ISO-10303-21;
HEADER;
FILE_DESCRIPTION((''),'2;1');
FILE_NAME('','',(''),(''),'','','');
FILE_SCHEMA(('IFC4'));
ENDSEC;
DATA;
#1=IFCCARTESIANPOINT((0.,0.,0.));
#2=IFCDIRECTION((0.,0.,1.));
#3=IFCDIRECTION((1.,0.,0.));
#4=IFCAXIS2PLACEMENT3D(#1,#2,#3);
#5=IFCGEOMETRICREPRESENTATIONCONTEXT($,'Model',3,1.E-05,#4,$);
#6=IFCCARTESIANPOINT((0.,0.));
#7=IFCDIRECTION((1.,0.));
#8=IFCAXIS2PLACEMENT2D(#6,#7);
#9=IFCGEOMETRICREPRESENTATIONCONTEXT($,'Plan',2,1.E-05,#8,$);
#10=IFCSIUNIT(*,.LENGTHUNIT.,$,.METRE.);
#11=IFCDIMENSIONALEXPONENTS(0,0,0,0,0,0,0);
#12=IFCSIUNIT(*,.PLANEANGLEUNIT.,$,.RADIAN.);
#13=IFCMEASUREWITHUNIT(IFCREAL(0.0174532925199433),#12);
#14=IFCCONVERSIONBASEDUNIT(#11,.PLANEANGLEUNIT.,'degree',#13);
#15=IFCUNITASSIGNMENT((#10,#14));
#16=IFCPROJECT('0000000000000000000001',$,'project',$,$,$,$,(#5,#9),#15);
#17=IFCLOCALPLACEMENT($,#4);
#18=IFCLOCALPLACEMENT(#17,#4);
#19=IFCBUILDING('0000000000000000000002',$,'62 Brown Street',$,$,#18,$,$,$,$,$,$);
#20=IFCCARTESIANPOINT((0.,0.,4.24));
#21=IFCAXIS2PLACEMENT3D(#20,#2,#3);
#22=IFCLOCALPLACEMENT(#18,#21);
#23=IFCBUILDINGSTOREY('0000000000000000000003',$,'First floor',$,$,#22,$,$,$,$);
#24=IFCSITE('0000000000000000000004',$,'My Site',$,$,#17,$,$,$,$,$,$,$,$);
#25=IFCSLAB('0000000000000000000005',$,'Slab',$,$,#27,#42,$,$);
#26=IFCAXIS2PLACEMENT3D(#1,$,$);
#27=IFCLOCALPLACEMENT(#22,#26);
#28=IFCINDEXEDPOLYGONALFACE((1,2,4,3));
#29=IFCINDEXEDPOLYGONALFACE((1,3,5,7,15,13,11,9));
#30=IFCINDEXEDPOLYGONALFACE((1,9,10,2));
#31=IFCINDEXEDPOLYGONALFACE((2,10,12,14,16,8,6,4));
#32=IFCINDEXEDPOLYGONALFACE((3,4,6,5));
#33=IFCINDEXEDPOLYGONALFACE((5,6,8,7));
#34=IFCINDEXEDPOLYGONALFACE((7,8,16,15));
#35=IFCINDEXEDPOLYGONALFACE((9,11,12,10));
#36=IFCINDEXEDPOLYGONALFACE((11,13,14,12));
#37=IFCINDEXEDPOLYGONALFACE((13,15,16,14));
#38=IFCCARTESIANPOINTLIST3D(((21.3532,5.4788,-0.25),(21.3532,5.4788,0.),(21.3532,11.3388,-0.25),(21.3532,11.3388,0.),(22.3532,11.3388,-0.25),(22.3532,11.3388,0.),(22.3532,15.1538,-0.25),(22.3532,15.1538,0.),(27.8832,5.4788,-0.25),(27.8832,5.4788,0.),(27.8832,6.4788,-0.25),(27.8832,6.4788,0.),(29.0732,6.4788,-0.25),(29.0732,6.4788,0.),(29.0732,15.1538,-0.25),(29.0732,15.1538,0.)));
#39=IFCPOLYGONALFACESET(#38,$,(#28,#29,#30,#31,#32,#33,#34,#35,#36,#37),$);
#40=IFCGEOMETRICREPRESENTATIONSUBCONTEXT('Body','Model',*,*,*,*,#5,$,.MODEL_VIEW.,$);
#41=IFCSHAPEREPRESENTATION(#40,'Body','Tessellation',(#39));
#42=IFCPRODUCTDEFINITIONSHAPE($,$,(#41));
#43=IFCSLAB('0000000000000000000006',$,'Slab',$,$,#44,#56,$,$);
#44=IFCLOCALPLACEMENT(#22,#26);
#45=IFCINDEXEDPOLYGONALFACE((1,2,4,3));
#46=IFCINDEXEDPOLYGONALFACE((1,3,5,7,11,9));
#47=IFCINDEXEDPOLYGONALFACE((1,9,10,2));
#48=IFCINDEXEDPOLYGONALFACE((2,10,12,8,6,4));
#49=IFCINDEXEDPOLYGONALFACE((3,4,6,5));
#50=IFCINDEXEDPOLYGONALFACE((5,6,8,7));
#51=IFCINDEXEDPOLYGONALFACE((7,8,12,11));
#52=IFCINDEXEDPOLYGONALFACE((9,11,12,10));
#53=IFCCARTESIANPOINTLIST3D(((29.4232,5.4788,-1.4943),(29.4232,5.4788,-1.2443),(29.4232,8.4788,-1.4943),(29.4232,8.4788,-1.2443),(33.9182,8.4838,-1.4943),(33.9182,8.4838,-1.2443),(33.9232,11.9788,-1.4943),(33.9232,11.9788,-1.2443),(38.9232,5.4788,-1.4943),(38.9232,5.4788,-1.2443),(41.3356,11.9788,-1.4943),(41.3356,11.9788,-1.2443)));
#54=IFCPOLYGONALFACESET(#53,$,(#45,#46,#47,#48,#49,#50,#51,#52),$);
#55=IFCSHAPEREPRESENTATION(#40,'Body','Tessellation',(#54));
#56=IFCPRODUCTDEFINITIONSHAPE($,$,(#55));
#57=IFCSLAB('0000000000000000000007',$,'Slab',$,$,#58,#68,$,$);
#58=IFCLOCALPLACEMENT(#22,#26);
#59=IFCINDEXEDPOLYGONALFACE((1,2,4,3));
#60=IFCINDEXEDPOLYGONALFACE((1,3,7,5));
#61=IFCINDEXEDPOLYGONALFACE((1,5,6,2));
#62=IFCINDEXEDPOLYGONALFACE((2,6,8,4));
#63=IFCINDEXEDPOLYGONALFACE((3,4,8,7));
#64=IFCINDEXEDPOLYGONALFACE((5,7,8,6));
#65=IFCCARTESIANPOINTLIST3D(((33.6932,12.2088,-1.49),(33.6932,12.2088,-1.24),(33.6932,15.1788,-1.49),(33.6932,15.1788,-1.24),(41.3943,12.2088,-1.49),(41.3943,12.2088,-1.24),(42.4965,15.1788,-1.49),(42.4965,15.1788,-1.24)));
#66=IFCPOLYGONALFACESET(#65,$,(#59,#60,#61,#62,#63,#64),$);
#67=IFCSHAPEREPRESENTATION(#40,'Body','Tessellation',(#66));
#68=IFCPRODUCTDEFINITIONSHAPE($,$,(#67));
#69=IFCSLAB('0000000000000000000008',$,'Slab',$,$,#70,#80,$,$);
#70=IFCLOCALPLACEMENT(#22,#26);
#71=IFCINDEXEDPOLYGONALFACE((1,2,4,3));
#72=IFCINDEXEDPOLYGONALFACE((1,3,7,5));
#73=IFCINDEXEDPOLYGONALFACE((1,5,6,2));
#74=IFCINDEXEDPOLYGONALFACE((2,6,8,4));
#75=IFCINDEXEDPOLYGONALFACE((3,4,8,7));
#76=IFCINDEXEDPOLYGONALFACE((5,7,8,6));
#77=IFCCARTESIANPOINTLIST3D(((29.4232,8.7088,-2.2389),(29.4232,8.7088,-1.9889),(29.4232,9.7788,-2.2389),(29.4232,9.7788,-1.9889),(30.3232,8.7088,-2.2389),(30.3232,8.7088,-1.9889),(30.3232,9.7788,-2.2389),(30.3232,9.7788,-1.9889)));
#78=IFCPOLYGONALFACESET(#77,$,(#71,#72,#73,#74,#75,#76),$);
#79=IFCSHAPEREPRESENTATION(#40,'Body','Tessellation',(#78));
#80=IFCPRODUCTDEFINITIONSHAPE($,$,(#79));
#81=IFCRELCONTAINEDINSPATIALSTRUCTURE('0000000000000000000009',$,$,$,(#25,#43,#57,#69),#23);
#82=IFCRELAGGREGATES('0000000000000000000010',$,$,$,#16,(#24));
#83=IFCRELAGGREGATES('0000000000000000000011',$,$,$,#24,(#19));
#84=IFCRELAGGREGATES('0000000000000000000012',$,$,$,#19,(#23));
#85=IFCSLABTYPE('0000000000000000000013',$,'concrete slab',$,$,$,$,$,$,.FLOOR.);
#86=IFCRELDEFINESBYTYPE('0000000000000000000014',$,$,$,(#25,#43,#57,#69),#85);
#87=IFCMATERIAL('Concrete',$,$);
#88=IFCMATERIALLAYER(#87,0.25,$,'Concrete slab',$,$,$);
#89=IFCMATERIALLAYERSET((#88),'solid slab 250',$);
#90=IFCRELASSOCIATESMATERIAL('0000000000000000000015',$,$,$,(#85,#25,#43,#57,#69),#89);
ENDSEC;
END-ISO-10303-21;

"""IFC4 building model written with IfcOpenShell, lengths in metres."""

from ifc_helpers import new_model, entity, si_unit, converted_unit, frame, origin_with_axes, origin_2d_with_axis, place, context, subcontext, project, spatial, line, indexed_curve, outline, extrude, material, layer, layer_set, layer_usage, type_object, element, save


model = new_model("IFC4")

# Units and contexts
model_context = context("Model", 3, precision=1e-05, world=origin_with_axes())
plan_context = context("Plan", 2, precision=1e-05, world=origin_2d_with_axis())
body_context = subcontext(model_context, "Body", "Model", "MODEL_VIEW")
ifc_project = project(units=[si_unit("LENGTHUNIT", "METRE"), converted_unit("PLANEANGLEUNIT", "degree", entity("IfcReal", 0.0174532925199433), si_unit("PLANEANGLEUNIT", "RADIAN"), dimensions=[0, 0, 0, 0, 0, 0, 0])], contexts=[model_context, plan_context])

# Site, building, storey
site_placement = place(None, origin_with_axes())
site = spatial("IfcSite", under=ifc_project, at=site_placement, Name="My Site")
building_placement = place(site_placement, origin_with_axes())
building = spatial("IfcBuilding", under=site, at=building_placement, Name="62 Brown Street")
storey_placement = place(building_placement, frame((0.0, 0.0, 4.24), z_axis=(0.0, 0.0, 1.0), x_axis=(1.0, 0.0, 0.0)))
storey = spatial("IfcBuildingStorey", under=building, at=storey_placement, Name="First floor")

# Slabs
ifc_material = material(Name="Concrete")
ifc_layer = layer(ifc_material, 0.25, Name="Concrete slab")
ifc_layer_set = layer_set([ifc_layer], Name="solid slab 250")
ifc_layer_usage_1 = layer_usage(ifc_layer_set, "AXIS3", "POSITIVE", 0.0)
slab_type = type_object("IfcSlabType", Name="concrete slab", PredefinedType="FLOOR", material=ifc_layer_set)
slab_1_placement = place(storey_placement, frame((21.3532, 5.4788, -0.25), z_axis=(0.0, 0.0, 1.0), x_axis=(1.0, 0.0, 0.0)))
element("IfcSlab", 1, at=slab_1_placement, inside=storey, type_object=slab_type, material=ifc_layer_usage_1, Name="Slab", context=body_context, shape_type="SweptSolid", body=[
    extrude(outline(indexed_curve([(0.0, 0.0), (0.0, 5.86), (1.0, 5.86), (1.0, 9.675), (7.72, 9.675), (7.72, 1.0), (6.53, 1.0), (6.53, 0.0)], segments=[line(2, 1), line(1, 8), line(8, 7), line(7, 6), line(6, 5), line(5, 4), line(4, 3), line(3, 2)], self_intersect=False)), None, (0.0, 0.0, 1.0), 0.25),
])
ifc_layer_usage_2 = layer_usage(ifc_layer_set, "AXIS3", "POSITIVE", 0.0)
slab_2_placement = place(storey_placement, frame((29.4232, 5.4788, -1.4943), z_axis=(0.0, 0.0, 1.0), x_axis=(1.0, 0.0, 0.0)))
element("IfcSlab", 2, at=slab_2_placement, inside=storey, type_object=slab_type, material=ifc_layer_usage_2, Name="Slab", context=body_context, shape_type="SweptSolid", body=[
    extrude(outline(indexed_curve([(0.0, 0.0), (9.5, 0.0), (11.9124, 6.5), (0.0, 3.0), (4.5, 6.5), (4.495, 3.005)], segments=[line(1, 2), line(2, 3), line(3, 5), line(5, 6), line(6, 4), line(4, 1)], self_intersect=False)), None, (0.0, 0.0, 1.0), 0.25),
])
ifc_layer_usage_3 = layer_usage(ifc_layer_set, "AXIS3", "POSITIVE", 0.0)
slab_3_placement = place(storey_placement, frame((33.6932, 12.2088, -1.49), z_axis=(0.0, 0.0, 1.0), x_axis=(1.0, 0.0, 0.0)))
element("IfcSlab", 3, at=slab_3_placement, inside=storey, type_object=slab_type, material=ifc_layer_usage_3, Name="Slab", context=body_context, shape_type="SweptSolid", body=[
    extrude(outline(indexed_curve([(8.8033, 2.97), (7.7011, 0.0), (0.0, 0.0), (0.0, 2.97)], segments=[line(4, 1), line(1, 2), line(2, 3), line(3, 4)], self_intersect=False)), None, (0.0, 0.0, 1.0), 0.25),
])
ifc_layer_usage_4 = layer_usage(ifc_layer_set, "AXIS3", "POSITIVE", 0.0)
slab_4_placement = place(storey_placement, frame((29.4232, 8.7088, -2.2389), z_axis=(0.0, 0.0, 1.0), x_axis=(1.0, 0.0, 0.0)))
element("IfcSlab", 4, at=slab_4_placement, inside=storey, type_object=slab_type, material=ifc_layer_usage_4, Name="Slab", context=body_context, shape_type="SweptSolid", body=[
    extrude(outline(indexed_curve([(0.9, 1.07), (0.9, 0.0), (0.0, 0.0), (0.0, 1.07)], segments=[line(3, 2), line(2, 1), line(1, 4), line(4, 3)], self_intersect=False)), None, (0.0, 0.0, 1.0), 0.25),
])

save(model, "model.ifc")
